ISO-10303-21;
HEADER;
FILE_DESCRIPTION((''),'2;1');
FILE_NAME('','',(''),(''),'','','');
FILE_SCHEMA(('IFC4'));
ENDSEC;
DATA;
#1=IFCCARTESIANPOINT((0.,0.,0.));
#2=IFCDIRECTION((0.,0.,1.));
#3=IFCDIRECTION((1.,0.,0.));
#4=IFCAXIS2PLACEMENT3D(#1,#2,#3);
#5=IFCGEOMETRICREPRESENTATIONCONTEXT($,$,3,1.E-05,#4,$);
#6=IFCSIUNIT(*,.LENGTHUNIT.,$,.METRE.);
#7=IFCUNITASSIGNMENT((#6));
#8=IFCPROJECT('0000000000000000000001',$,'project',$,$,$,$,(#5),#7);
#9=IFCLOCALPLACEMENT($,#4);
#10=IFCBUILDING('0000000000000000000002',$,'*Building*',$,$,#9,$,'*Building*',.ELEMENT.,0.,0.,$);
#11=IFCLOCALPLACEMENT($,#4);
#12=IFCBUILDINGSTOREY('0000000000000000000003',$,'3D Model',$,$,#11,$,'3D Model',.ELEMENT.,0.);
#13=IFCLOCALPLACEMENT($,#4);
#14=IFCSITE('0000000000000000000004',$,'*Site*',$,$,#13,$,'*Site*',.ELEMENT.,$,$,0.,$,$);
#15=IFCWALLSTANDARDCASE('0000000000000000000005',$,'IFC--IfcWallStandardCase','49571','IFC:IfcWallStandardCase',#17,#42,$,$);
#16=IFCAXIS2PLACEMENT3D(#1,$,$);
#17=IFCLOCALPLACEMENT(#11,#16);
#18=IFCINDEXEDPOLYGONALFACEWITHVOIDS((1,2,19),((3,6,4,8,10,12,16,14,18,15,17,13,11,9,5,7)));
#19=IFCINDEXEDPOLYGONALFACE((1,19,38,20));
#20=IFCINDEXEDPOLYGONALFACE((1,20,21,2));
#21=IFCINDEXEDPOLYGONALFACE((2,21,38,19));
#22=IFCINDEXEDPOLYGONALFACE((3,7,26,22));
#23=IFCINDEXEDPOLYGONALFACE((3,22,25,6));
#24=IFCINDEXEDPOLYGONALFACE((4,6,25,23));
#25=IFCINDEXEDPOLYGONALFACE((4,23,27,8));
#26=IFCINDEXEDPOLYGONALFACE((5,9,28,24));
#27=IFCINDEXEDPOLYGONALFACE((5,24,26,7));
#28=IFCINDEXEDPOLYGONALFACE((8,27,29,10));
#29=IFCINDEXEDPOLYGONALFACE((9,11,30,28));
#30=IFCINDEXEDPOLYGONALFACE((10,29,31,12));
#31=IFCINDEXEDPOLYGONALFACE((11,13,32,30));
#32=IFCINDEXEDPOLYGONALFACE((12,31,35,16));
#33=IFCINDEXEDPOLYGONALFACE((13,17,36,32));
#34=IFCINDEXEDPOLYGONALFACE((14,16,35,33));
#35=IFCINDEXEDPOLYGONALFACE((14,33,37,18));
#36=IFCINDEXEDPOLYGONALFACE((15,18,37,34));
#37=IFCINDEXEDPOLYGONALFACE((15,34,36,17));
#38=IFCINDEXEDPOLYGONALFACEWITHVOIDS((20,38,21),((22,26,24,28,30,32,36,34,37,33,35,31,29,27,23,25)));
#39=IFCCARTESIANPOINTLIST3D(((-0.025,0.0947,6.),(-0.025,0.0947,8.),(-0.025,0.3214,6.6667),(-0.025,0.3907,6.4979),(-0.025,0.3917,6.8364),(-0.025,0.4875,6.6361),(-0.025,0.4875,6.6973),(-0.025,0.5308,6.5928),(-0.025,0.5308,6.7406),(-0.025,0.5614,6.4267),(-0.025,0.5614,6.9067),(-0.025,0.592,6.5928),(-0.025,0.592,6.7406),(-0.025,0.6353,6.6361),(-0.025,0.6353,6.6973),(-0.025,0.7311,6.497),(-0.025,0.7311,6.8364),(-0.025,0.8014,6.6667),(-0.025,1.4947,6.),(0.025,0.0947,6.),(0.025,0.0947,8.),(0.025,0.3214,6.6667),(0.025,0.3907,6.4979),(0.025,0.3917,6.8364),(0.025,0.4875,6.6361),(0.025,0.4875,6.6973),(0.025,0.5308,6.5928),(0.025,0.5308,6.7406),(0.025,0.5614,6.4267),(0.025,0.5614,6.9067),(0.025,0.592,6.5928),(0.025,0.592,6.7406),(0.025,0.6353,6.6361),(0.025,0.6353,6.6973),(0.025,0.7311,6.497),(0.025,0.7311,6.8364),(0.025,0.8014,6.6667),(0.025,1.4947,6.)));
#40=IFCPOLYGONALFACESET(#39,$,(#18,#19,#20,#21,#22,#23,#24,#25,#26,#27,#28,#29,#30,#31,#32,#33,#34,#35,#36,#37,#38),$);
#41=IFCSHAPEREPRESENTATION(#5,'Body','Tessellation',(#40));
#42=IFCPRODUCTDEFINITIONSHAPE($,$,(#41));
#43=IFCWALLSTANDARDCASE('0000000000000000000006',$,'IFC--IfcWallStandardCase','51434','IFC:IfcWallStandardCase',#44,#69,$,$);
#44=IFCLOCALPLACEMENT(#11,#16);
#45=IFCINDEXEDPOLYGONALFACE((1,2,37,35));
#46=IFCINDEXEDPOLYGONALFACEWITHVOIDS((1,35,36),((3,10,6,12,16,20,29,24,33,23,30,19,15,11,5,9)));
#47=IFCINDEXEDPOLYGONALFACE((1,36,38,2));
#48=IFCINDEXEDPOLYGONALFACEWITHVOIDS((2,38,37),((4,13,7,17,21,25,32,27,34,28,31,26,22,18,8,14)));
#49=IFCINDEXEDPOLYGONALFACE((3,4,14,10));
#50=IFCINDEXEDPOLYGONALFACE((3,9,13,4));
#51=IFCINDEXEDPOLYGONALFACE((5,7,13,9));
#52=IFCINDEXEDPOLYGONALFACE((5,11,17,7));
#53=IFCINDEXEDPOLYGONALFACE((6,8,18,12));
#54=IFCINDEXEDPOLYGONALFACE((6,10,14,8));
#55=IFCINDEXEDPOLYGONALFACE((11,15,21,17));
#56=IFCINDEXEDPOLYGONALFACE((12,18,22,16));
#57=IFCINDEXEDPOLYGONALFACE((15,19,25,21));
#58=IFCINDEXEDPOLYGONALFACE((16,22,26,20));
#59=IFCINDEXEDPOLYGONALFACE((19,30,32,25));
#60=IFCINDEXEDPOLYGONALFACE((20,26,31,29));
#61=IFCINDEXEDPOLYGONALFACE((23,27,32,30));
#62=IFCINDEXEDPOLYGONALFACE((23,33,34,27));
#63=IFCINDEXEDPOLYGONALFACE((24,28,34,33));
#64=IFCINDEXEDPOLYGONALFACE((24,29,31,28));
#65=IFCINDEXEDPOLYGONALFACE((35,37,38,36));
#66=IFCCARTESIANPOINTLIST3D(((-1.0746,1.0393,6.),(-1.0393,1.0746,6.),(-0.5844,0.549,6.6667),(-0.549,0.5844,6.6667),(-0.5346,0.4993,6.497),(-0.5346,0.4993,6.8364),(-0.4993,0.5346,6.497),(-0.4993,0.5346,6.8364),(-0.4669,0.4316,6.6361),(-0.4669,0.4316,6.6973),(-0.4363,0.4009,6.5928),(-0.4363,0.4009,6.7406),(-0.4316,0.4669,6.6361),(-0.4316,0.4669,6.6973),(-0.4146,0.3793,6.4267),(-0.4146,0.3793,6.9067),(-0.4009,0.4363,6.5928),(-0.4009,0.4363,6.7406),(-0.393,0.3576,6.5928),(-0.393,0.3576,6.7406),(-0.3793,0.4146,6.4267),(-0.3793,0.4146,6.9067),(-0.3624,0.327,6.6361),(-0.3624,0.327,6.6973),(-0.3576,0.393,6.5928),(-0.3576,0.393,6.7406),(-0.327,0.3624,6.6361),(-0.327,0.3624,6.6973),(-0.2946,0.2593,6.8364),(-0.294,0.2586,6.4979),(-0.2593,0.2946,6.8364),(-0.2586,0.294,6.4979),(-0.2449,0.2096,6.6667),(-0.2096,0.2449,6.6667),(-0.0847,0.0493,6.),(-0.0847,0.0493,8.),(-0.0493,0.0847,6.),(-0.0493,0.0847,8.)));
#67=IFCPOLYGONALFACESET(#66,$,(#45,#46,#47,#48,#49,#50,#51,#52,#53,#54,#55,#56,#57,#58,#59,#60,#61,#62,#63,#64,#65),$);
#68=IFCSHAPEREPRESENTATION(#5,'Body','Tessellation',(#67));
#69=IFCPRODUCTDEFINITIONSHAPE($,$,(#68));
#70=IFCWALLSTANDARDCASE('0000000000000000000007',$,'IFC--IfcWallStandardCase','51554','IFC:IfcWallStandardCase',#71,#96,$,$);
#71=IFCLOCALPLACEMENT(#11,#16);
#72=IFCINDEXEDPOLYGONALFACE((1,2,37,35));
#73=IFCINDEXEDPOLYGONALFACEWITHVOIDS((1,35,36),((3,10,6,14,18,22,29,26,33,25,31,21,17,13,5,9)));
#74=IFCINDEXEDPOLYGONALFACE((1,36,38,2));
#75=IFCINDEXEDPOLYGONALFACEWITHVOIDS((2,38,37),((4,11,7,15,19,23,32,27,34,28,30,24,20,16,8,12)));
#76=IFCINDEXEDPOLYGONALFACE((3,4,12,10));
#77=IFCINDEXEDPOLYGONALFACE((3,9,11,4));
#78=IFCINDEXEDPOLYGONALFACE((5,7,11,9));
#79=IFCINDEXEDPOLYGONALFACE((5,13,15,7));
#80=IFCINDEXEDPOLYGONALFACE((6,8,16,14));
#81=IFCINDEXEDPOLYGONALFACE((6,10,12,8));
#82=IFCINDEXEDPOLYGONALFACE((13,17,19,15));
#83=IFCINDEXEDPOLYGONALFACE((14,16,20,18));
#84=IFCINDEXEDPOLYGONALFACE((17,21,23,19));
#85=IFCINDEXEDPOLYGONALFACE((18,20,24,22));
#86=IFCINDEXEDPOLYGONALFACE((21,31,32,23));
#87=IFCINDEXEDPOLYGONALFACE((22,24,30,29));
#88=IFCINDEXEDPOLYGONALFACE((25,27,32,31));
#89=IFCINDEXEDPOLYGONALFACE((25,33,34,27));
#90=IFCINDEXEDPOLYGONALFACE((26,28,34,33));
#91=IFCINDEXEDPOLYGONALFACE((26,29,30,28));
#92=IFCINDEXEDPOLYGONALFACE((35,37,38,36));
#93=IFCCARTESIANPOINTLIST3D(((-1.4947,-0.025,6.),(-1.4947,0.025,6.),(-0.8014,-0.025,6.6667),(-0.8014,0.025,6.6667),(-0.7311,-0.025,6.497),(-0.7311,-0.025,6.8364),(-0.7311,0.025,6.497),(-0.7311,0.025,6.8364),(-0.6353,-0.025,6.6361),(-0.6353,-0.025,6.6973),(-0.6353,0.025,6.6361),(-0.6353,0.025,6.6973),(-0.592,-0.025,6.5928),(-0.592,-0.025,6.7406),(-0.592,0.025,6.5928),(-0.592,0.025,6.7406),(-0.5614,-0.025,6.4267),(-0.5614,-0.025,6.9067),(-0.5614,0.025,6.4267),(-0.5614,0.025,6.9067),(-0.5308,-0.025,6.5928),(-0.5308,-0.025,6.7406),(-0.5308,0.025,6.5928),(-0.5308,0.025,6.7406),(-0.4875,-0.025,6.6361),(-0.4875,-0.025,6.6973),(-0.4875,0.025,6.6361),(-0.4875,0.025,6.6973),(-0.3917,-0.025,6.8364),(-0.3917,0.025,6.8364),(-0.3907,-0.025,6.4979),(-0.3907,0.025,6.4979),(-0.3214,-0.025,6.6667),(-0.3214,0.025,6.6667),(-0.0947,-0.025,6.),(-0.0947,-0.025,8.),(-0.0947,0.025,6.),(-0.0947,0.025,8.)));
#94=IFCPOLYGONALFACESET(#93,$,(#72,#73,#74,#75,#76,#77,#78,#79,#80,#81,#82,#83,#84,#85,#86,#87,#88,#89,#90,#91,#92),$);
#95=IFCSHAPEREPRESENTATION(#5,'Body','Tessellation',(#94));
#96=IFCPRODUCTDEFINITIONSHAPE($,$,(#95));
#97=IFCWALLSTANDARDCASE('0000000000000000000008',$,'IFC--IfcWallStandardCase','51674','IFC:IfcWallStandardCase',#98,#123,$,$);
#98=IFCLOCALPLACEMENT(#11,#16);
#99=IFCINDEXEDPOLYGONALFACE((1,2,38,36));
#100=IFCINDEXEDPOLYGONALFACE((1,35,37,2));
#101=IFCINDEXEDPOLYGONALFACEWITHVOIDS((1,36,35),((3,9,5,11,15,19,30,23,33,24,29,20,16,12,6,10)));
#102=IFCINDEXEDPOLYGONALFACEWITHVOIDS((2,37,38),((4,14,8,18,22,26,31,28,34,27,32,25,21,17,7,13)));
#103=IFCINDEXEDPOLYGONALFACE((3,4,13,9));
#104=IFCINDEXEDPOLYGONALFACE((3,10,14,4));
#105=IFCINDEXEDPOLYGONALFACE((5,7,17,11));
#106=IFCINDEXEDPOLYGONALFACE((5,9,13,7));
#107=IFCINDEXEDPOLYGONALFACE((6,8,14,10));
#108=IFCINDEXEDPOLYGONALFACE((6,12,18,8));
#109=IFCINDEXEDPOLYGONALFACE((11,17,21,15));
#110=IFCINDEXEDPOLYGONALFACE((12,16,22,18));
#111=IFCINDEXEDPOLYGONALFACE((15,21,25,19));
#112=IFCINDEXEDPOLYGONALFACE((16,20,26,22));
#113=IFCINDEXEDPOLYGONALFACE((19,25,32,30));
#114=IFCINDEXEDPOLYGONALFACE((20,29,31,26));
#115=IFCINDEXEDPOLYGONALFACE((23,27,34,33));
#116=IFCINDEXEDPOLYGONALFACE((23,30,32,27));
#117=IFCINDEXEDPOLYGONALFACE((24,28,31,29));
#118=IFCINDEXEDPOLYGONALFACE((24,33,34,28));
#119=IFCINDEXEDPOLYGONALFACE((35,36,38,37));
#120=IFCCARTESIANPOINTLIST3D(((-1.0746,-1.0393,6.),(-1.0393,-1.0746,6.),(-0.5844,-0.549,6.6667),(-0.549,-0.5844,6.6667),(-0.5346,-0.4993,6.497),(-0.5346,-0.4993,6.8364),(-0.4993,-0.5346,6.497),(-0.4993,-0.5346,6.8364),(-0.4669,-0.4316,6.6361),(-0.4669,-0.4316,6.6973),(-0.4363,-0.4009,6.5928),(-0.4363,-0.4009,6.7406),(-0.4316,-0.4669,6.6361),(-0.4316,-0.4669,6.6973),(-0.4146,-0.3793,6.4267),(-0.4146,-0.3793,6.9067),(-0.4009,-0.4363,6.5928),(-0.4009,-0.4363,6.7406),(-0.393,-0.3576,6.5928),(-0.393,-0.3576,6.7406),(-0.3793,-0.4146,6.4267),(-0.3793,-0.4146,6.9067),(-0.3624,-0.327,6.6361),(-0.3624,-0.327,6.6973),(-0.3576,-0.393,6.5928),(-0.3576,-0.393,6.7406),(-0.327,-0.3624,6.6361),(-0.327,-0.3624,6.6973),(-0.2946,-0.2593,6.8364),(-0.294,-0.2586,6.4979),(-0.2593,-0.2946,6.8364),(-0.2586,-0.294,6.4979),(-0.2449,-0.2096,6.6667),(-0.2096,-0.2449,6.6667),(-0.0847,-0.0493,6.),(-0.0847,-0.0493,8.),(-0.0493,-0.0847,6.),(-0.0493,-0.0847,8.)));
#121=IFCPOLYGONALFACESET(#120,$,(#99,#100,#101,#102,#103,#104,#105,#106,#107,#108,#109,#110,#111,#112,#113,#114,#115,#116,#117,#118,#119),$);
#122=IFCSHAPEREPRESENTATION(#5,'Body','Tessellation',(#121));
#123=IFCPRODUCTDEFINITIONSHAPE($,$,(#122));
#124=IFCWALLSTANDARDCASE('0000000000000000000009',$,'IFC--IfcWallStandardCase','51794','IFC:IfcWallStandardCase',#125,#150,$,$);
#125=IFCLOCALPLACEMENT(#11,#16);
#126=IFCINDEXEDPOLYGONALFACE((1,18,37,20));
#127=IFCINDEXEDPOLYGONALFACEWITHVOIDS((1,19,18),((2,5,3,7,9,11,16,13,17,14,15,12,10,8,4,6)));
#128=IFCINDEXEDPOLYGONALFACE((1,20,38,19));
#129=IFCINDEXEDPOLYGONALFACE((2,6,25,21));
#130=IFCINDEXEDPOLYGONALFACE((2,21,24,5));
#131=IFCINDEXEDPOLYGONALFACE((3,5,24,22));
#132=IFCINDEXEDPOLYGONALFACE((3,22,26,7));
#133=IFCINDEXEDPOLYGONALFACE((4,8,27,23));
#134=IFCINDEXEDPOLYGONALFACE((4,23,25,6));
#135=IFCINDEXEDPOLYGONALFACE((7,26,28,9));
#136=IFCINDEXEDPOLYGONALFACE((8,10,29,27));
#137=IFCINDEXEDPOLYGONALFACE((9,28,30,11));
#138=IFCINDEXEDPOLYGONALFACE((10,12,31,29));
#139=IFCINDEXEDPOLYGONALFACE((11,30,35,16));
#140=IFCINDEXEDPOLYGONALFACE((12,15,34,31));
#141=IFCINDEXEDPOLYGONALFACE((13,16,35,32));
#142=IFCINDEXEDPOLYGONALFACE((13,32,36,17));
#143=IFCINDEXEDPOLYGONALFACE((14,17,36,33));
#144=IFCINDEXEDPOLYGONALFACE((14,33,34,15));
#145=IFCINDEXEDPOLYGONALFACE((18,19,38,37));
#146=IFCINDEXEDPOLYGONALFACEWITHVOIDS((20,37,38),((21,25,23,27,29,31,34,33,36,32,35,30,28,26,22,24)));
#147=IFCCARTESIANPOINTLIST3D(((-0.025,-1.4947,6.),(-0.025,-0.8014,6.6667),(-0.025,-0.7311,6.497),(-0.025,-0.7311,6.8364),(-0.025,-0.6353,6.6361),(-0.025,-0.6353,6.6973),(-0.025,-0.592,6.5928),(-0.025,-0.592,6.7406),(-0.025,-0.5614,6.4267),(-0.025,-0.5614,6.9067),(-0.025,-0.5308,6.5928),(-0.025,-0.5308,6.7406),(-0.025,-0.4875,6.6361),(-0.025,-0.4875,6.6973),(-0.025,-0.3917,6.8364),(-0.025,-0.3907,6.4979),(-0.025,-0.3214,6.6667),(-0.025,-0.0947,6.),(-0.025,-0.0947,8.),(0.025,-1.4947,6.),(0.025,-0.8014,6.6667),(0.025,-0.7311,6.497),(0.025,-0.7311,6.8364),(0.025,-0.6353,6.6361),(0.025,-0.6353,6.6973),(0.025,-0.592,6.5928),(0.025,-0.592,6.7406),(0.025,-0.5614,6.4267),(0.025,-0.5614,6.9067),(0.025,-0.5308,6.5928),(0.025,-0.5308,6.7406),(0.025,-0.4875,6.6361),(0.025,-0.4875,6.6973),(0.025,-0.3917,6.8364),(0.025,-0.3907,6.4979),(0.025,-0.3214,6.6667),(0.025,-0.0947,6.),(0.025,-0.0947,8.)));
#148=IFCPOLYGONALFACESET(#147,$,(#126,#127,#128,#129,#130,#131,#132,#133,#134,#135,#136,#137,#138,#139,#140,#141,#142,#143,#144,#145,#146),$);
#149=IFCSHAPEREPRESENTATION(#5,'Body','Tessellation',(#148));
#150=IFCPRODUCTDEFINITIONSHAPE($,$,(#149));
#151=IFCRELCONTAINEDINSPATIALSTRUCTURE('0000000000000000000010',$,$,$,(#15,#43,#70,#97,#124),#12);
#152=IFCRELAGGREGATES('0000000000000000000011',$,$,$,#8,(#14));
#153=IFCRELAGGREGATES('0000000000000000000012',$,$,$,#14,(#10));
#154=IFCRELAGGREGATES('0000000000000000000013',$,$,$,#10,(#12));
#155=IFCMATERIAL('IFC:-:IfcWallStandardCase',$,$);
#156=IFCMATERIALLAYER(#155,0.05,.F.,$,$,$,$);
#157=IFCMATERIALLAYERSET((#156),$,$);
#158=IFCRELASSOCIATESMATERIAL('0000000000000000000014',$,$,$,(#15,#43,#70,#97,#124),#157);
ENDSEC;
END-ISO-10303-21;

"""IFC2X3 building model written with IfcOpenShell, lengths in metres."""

from ifc_helpers import new_model, si_unit, frame, frame_2d, origin_with_axes, place, context, project, spatial, polyline, rectangle, outline, extrude, clip, halfspace, material, layer, layer_set, layer_usage, element, save


model = new_model("IFC2X3")

# Units and contexts
context_of_model = context(None, 3, precision=1e-05, world=origin_with_axes())
ifc_project = project(units=[si_unit("LENGTHUNIT", "METRE")], contexts=[context_of_model])

# Site, building, storey
site_placement = place(None, origin_with_axes())
site = spatial("IfcSite", under=ifc_project, at=site_placement, Name="*Site*", LongName="*Site*", CompositionType="ELEMENT", RefElevation=0.0)
building_placement = place(None, origin_with_axes())
building = spatial("IfcBuilding", under=site, at=building_placement, Name="*Building*", LongName="*Building*", CompositionType="ELEMENT", ElevationOfRefHeight=0.0, ElevationOfTerrain=0.0)
storey_placement = place(None, origin_with_axes())
storey = spatial("IfcBuildingStorey", under=building, at=storey_placement, Name="3D Model", LongName="3D Model", CompositionType="ELEMENT", Elevation=0.0)

# Walls, openings
ifc_material = material(Name="IFC:-:IfcWallStandardCase")
ifc_layer = layer(ifc_material, 0.05, ventilated=False)
ifc_layer_set = layer_set([ifc_layer])
ifc_layer_usage = layer_usage(ifc_layer_set, "AXIS2", "POSITIVE", 0.0)
wall_1_placement = place(None, frame((0.0, 0.0947, 6.0), z_axis=(0.0, 0.0, 1.0), x_axis=(-0.000003, 1.0, 0.0)))
wall_1 = element("IfcWallStandardCase", 1, at=wall_1_placement, inside=storey, material=ifc_layer_usage, Name="IFC--IfcWallStandardCase", Description="49571", ObjectType="IFC:IfcWallStandardCase", context=context_of_model, shape_type="Clipping", body=[
    clip(extrude(rectangle(XDim=1.4, YDim=0.05, at=frame_2d((0.7, 0.0), x_axis=(1.0, 0.0))), origin_with_axes(), (0.0, 0.0, 1.0), 2.0), halfspace(frame((0.9396, 0.0, 0.6577), z_axis=(-0.819232, 0.000002, -0.573462), x_axis=(-0.000003, -1.0, 0.0)), True)),
])
opening_1_placement = place(wall_1_placement, frame((0.2267, 0.025, 0.4267), z_axis=(0.0, 0.0, 1.0), x_axis=(1.0, 0.0, 0.0)))
element("IfcOpeningElement", 2, at=opening_1_placement, cuts=wall_1, context=context_of_model, shape_type="SweptSolid", body=[
    extrude(outline(polyline([(-0.3139, 0.2094), (-0.4097, 0.0703), (-0.2706, 0.1661), (-0.24, 0.0), (-0.2094, 0.1661), (-0.0693, 0.0713), (-0.1661, 0.2094), (0.0, 0.24), (-0.1661, 0.2706), (-0.0703, 0.4097), (-0.2094, 0.3139), (-0.24, 0.48), (-0.2706, 0.3139), (-0.4097, 0.4097), (-0.3139, 0.2706), (-0.48, 0.24), (-0.3139, 0.2094)])), frame((0.0, 0.0, 0.0), z_axis=(0.0, 1.0, 0.0), x_axis=(-1.0, 0.0, 0.0)), (0.0, 0.0, -1.0), 0.15),
])
wall_2_placement = place(None, frame((-0.067, 0.067, 6.0), z_axis=(0.0, 0.0, 1.0), x_axis=(-0.707109, 0.707105, 0.0)))
wall_2 = element("IfcWallStandardCase", 3, at=wall_2_placement, inside=storey, material=ifc_layer_usage, Name="IFC--IfcWallStandardCase", Description="51434", ObjectType="IFC:IfcWallStandardCase", context=context_of_model, shape_type="Clipping", body=[
    clip(extrude(rectangle(XDim=1.4, YDim=0.05, at=frame_2d((0.7, 0.0), x_axis=(1.0, 0.0))), origin_with_axes(), (0.0, 0.0, 1.0), 2.0), halfspace(frame((0.9396, 0.0, 0.6577), z_axis=(-0.819232, 0.000002, -0.573462), x_axis=(-0.000003, -1.0, 0.0)), True)),
])
opening_2_placement = place(wall_2_placement, frame((0.2267, 0.025, 0.4267), z_axis=(0.0, 0.0, 1.0), x_axis=(1.0, 0.0, 0.0)))
element("IfcOpeningElement", 4, at=opening_2_placement, cuts=wall_2, context=context_of_model, shape_type="SweptSolid", body=[
    extrude(outline(polyline([(-0.3139, 0.2094), (-0.4097, 0.0703), (-0.2706, 0.1661), (-0.24, 0.0), (-0.2094, 0.1661), (-0.0693, 0.0713), (-0.1661, 0.2094), (0.0, 0.24), (-0.1661, 0.2706), (-0.0703, 0.4097), (-0.2094, 0.3139), (-0.24, 0.48), (-0.2706, 0.3139), (-0.4097, 0.4097), (-0.3139, 0.2706), (-0.48, 0.24), (-0.3139, 0.2094)])), frame((0.0, 0.0, 0.0), z_axis=(0.0, 1.0, 0.0), x_axis=(-1.0, 0.0, 0.0)), (0.0, 0.0, -1.0), 0.15),
])
wall_3_placement = place(None, frame((-0.0947, 0.0, 6.0), z_axis=(0.0, 0.0, 1.0), x_axis=(-1.0, -0.000003, 0.0)))
wall_3 = element("IfcWallStandardCase", 5, at=wall_3_placement, inside=storey, material=ifc_layer_usage, Name="IFC--IfcWallStandardCase", Description="51554", ObjectType="IFC:IfcWallStandardCase", context=context_of_model, shape_type="Clipping", body=[
    clip(extrude(rectangle(XDim=1.4, YDim=0.05, at=frame_2d((0.7, 0.0), x_axis=(1.0, 0.0))), origin_with_axes(), (0.0, 0.0, 1.0), 2.0), halfspace(frame((0.9396, 0.0, 0.6577), z_axis=(-0.819232, 0.000002, -0.573462), x_axis=(-0.000003, -1.0, 0.0)), True)),
])
opening_3_placement = place(wall_3_placement, frame((0.2267, 0.025, 0.4267), z_axis=(0.0, 0.0, 1.0), x_axis=(1.0, 0.0, 0.0)))
element("IfcOpeningElement", 6, at=opening_3_placement, cuts=wall_3, context=context_of_model, shape_type="SweptSolid", body=[
    extrude(outline(polyline([(-0.3139, 0.2094), (-0.4097, 0.0703), (-0.2706, 0.1661), (-0.24, 0.0), (-0.2094, 0.1661), (-0.0693, 0.0713), (-0.1661, 0.2094), (0.0, 0.24), (-0.1661, 0.2706), (-0.0703, 0.4097), (-0.2094, 0.3139), (-0.24, 0.48), (-0.2706, 0.3139), (-0.4097, 0.4097), (-0.3139, 0.2706), (-0.48, 0.24), (-0.3139, 0.2094)])), frame((0.0, 0.0, 0.0), z_axis=(0.0, 1.0, 0.0), x_axis=(-1.0, 0.0, 0.0)), (0.0, 0.0, -1.0), 0.15),
])
wall_4_placement = place(None, frame((-0.067, -0.067, 6.0), z_axis=(0.0, 0.0, 1.0), x_axis=(-0.707105, -0.707109, 0.0)))
wall_4 = element("IfcWallStandardCase", 7, at=wall_4_placement, inside=storey, material=ifc_layer_usage, Name="IFC--IfcWallStandardCase", Description="51674", ObjectType="IFC:IfcWallStandardCase", context=context_of_model, shape_type="Clipping", body=[
    clip(extrude(rectangle(XDim=1.4, YDim=0.05, at=frame_2d((0.7, 0.0), x_axis=(1.0, 0.0))), origin_with_axes(), (0.0, 0.0, 1.0), 2.0), halfspace(frame((0.9396, 0.0, 0.6577), z_axis=(-0.819232, 0.000002, -0.573462), x_axis=(-0.000003, -1.0, 0.0)), True)),
])
opening_4_placement = place(wall_4_placement, frame((0.2267, 0.025, 0.4267), z_axis=(0.0, 0.0, 1.0), x_axis=(1.0, 0.0, 0.0)))
element("IfcOpeningElement", 8, at=opening_4_placement, cuts=wall_4, context=context_of_model, shape_type="SweptSolid", body=[
    extrude(outline(polyline([(-0.3139, 0.2094), (-0.4097, 0.0703), (-0.2706, 0.1661), (-0.24, 0.0), (-0.2094, 0.1661), (-0.0693, 0.0713), (-0.1661, 0.2094), (0.0, 0.24), (-0.1661, 0.2706), (-0.0703, 0.4097), (-0.2094, 0.3139), (-0.24, 0.48), (-0.2706, 0.3139), (-0.4097, 0.4097), (-0.3139, 0.2706), (-0.48, 0.24), (-0.3139, 0.2094)])), frame((0.0, 0.0, 0.0), z_axis=(0.0, 1.0, 0.0), x_axis=(-1.0, 0.0, 0.0)), (0.0, 0.0, -1.0), 0.15),
])
wall_5_placement = place(None, frame((0.0, -0.0947, 6.0), z_axis=(0.0, 0.0, 1.0), x_axis=(0.000003, -1.0, 0.0)))
wall_5 = element("IfcWallStandardCase", 9, at=wall_5_placement, inside=storey, material=ifc_layer_usage, Name="IFC--IfcWallStandardCase", Description="51794", ObjectType="IFC:IfcWallStandardCase", context=context_of_model, shape_type="Clipping", body=[
    clip(extrude(rectangle(XDim=1.4, YDim=0.05, at=frame_2d((0.7, 0.0), x_axis=(1.0, 0.0))), origin_with_axes(), (0.0, 0.0, 1.0), 2.0), halfspace(frame((0.9396, 0.0, 0.6577), z_axis=(-0.819232, 0.000002, -0.573462), x_axis=(-0.000003, -1.0, 0.0)), True)),
])
opening_5_placement = place(wall_5_placement, frame((0.2267, 0.025, 0.4267), z_axis=(0.0, 0.0, 1.0), x_axis=(1.0, 0.0, 0.0)))
element("IfcOpeningElement", 10, at=opening_5_placement, cuts=wall_5, context=context_of_model, shape_type="SweptSolid", body=[
    extrude(outline(polyline([(-0.3139, 0.2094), (-0.4097, 0.0703), (-0.2706, 0.1661), (-0.24, 0.0), (-0.2094, 0.1661), (-0.0693, 0.0713), (-0.1661, 0.2094), (0.0, 0.24), (-0.1661, 0.2706), (-0.0703, 0.4097), (-0.2094, 0.3139), (-0.24, 0.48), (-0.2706, 0.3139), (-0.4097, 0.4097), (-0.3139, 0.2706), (-0.48, 0.24), (-0.3139, 0.2094)])), frame((0.0, 0.0, 0.0), z_axis=(0.0, 1.0, 0.0), x_axis=(-1.0, 0.0, 0.0)), (0.0, 0.0, -1.0), 0.15),
])

save(model, "model.ifc")
